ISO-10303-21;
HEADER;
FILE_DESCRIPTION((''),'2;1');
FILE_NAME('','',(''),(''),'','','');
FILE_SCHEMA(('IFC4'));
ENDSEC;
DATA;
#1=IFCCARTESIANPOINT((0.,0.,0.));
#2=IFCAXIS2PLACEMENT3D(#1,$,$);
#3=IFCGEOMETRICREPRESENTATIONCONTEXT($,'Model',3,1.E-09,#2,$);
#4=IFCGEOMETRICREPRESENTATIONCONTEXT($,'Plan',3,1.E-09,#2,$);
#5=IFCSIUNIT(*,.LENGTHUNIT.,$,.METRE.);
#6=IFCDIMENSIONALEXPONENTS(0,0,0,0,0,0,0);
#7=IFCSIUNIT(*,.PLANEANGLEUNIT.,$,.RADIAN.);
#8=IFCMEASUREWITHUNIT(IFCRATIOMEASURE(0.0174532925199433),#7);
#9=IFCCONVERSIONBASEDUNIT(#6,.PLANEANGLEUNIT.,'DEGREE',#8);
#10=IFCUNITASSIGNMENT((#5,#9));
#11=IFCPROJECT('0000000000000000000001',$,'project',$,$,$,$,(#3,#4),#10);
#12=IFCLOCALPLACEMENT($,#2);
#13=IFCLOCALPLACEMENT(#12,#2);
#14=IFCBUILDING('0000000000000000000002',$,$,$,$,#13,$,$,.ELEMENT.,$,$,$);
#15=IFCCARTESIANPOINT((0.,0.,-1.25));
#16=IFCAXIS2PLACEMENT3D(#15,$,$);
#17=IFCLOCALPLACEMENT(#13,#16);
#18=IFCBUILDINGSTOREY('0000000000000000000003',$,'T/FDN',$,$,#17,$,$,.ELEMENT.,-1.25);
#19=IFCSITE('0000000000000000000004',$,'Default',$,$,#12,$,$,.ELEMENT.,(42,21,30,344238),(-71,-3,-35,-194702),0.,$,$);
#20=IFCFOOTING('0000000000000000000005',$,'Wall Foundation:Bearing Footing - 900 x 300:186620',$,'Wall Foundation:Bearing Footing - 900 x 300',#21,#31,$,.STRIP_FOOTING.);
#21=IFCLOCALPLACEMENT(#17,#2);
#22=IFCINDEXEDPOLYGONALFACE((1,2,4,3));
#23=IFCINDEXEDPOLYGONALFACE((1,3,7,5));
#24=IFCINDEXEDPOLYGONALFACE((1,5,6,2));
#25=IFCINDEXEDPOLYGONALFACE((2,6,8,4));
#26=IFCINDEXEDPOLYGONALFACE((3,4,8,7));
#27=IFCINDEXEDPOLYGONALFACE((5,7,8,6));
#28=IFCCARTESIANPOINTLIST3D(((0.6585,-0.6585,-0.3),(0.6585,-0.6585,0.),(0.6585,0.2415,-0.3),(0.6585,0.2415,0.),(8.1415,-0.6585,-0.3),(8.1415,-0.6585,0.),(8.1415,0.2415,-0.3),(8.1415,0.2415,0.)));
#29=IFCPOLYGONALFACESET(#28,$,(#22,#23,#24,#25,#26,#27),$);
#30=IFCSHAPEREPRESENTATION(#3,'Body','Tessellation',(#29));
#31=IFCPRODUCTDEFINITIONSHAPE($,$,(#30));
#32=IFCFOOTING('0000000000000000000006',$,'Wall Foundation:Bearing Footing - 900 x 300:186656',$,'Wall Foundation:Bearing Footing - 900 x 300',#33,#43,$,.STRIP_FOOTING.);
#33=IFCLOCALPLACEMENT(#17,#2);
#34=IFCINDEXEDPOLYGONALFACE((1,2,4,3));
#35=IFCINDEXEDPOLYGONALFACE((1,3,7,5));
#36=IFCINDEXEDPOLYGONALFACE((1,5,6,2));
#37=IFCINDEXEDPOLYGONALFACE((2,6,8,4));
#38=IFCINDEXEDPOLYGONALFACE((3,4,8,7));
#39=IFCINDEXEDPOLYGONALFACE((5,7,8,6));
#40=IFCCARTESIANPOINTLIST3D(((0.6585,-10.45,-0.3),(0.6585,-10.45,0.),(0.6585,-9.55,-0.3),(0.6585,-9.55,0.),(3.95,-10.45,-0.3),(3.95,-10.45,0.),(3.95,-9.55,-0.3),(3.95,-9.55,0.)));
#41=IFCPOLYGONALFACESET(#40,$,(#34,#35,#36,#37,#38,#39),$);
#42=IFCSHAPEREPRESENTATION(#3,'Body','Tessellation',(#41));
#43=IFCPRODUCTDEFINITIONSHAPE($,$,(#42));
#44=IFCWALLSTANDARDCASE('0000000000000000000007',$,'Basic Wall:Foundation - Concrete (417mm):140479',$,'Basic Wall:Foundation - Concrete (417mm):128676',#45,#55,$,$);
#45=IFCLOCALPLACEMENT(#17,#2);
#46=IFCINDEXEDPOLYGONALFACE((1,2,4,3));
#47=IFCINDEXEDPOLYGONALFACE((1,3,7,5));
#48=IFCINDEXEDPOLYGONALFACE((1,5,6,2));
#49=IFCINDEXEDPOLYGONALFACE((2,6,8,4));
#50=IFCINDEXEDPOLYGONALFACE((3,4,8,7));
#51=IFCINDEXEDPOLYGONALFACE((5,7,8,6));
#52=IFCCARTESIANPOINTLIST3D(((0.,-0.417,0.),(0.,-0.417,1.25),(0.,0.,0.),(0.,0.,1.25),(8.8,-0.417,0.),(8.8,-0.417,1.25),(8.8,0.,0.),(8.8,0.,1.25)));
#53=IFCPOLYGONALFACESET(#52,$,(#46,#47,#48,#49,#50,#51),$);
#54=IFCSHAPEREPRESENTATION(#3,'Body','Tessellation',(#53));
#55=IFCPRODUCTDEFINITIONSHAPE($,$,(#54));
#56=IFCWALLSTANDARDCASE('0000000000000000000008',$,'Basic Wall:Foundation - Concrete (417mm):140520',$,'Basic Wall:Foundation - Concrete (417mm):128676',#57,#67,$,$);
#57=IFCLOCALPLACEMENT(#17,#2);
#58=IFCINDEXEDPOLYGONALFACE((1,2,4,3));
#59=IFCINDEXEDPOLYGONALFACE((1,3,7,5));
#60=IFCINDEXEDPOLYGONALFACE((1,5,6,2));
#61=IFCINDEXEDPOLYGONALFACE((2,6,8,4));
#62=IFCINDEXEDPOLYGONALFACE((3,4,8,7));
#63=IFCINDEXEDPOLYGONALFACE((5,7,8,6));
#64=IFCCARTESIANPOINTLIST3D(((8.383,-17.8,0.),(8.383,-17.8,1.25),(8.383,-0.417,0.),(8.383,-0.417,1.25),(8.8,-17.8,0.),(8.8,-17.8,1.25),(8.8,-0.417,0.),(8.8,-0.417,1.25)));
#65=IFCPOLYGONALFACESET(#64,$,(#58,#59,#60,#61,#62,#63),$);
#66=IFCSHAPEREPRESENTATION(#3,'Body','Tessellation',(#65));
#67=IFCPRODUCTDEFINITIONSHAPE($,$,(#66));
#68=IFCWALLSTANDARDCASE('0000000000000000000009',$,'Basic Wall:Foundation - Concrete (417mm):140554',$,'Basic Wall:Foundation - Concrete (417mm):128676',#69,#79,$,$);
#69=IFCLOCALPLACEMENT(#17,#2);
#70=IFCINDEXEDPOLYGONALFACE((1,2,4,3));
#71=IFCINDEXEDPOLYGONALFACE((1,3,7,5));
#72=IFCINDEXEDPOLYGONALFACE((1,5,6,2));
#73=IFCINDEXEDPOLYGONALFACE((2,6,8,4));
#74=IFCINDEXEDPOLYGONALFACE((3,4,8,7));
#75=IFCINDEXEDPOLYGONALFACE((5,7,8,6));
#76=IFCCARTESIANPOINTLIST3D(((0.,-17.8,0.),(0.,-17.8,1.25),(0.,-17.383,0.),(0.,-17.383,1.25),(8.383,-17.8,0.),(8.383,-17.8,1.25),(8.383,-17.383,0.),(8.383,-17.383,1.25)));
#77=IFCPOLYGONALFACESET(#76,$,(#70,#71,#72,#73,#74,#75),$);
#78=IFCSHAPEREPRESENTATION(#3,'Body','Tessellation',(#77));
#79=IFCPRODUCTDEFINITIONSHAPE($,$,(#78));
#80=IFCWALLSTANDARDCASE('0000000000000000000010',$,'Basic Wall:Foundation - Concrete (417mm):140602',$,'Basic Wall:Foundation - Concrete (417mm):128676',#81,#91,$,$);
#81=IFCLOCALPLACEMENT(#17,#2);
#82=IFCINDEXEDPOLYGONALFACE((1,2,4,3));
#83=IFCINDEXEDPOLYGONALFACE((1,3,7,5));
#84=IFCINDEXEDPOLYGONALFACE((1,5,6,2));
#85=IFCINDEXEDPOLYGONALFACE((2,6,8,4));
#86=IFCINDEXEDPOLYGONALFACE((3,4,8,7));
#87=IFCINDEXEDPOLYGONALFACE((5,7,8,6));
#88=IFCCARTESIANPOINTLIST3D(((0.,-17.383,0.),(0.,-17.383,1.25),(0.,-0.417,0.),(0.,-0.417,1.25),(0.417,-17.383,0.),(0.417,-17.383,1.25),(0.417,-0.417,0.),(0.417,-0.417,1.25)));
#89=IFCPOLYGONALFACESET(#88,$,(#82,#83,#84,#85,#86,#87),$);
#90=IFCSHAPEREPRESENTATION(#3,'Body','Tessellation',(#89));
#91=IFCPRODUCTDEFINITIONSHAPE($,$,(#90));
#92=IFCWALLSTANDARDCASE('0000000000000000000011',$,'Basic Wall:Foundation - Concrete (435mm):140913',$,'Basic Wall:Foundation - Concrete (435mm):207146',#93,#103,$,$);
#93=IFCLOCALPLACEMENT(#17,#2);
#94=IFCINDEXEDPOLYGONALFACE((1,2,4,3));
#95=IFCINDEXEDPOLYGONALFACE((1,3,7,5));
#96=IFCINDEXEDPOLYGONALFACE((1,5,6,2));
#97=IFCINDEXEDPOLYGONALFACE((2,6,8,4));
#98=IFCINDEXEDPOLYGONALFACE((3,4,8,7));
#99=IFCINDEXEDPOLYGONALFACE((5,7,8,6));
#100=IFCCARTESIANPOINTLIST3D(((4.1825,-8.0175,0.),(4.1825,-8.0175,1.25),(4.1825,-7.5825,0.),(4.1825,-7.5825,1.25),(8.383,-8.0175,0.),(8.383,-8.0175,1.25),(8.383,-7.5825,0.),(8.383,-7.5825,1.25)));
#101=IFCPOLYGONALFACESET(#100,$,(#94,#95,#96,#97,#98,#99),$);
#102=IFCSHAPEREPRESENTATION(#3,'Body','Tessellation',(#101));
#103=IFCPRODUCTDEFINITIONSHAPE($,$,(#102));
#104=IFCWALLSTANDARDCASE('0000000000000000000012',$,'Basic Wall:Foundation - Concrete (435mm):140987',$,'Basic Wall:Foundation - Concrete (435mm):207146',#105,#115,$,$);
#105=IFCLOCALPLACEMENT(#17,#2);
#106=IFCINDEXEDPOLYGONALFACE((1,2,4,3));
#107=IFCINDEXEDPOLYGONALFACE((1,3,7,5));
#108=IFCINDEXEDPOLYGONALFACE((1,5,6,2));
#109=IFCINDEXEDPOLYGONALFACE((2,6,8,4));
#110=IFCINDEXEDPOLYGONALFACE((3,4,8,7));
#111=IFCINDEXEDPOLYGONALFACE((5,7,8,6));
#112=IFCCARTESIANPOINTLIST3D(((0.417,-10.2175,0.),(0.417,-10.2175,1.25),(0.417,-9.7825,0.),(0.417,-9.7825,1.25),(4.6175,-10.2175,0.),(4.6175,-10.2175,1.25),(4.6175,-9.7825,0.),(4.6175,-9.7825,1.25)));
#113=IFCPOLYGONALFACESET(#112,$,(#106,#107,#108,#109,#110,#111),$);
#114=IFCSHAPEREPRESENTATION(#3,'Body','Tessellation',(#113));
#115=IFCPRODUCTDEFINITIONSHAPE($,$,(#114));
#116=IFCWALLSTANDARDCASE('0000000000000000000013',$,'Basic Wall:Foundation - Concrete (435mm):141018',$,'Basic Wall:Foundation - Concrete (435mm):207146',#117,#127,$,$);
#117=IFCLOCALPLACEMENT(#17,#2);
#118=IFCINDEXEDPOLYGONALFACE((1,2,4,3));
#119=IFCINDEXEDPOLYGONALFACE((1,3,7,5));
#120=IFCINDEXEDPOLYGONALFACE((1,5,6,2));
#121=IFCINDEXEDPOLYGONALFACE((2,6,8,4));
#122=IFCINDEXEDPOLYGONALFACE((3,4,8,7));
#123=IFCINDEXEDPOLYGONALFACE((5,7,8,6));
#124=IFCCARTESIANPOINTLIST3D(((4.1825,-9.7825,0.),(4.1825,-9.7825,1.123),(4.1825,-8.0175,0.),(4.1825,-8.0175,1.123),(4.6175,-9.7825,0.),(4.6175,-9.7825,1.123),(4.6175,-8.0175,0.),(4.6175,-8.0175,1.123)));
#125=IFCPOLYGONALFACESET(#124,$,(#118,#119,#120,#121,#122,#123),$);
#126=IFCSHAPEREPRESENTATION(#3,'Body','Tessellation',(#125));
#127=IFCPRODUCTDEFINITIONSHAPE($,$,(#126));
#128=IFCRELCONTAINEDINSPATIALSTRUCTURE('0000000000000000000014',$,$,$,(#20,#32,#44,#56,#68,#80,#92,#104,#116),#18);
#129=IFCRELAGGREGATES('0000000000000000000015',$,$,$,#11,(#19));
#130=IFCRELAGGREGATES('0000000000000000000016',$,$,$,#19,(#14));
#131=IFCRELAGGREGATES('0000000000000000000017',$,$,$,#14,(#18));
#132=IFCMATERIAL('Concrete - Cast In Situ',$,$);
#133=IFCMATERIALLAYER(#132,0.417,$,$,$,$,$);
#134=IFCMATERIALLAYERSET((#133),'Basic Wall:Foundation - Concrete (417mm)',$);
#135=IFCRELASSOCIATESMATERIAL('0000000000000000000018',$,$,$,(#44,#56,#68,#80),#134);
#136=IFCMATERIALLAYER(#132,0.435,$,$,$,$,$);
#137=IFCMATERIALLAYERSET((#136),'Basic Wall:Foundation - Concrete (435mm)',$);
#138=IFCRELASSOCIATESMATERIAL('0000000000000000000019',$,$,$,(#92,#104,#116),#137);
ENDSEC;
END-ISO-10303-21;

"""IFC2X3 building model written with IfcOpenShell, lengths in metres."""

from ifc_helpers import new_model, entity, si_unit, converted_unit, frame, frame_2d, origin, origin_2d_with_axis, place, context, project, spatial, rectangle, extrude, material, layer, layer_set, layer_usage, element, save


model = new_model("IFC2X3")

# Units and contexts
model_context = context("Model", 3, precision=1e-09, world=origin())
plan_context = context("Plan", 3, precision=1e-09, world=origin())
ifc_project = project(units=[si_unit("LENGTHUNIT", "METRE"), converted_unit("PLANEANGLEUNIT", "DEGREE", entity("IfcRatioMeasure", 0.0174532925199433), si_unit("PLANEANGLEUNIT", "RADIAN"), dimensions=[0, 0, 0, 0, 0, 0, 0])], contexts=[model_context, plan_context])

# Site, building, storey
site_placement = place(None, origin())
site = spatial("IfcSite", under=ifc_project, at=site_placement, Name="Default", CompositionType="ELEMENT", RefLatitude=(42, 21, 30, 344238), RefLongitude=(-71, -3, -35, -194702), RefElevation=0.0)
building_placement = place(site_placement, origin())
building = spatial("IfcBuilding", under=site, at=building_placement, CompositionType="ELEMENT")
storey_placement = place(building_placement, frame((0.0, 0.0, -1.25)))
storey = spatial("IfcBuildingStorey", under=building, at=storey_placement, Name="T/FDN", CompositionType="ELEMENT", Elevation=-1.25)

# Footings
placement = place(storey_placement, origin())
element("IfcFooting", 1, at=placement, inside=storey, Name="Wall Foundation:Bearing Footing - 900 x 300:186620", ObjectType="Wall Foundation:Bearing Footing - 900 x 300", PredefinedType="STRIP_FOOTING", context=model_context, shape_type="SweptSolid", body=[
    extrude(rectangle(XDim=7.483, YDim=0.9, at=origin_2d_with_axis()), frame((4.4, -0.2085, -0.3), z_axis=(0.0, 0.0, 1.0), x_axis=(-1.0, 0.0, 0.0)), (0.0, 0.0, 1.0), 0.3),
])
element("IfcFooting", 2, at=placement, inside=storey, Name="Wall Foundation:Bearing Footing - 900 x 300:186656", ObjectType="Wall Foundation:Bearing Footing - 900 x 300", PredefinedType="STRIP_FOOTING", context=model_context, shape_type="SweptSolid", body=[
    extrude(rectangle(XDim=3.2915, YDim=0.9, at=origin_2d_with_axis()), frame((2.3043, -10.0, -0.3)), (0.0, 0.0, 1.0), 0.3),
])

# Walls
ifc_material = material(Name="Concrete - Cast In Situ")
ifc_layer_1 = layer(ifc_material, 0.417)
ifc_layer_set_1 = layer_set([ifc_layer_1], Name="Basic Wall:Foundation - Concrete (417mm)")
ifc_layer_usage_1 = layer_usage(ifc_layer_set_1, "AXIS2", "NEGATIVE", 0.2085)
wall_1_placement = place(storey_placement, frame((0.0, -0.2085, 0.0)))
element("IfcWallStandardCase", 3, at=wall_1_placement, inside=storey, material=ifc_layer_usage_1, Name="Basic Wall:Foundation - Concrete (417mm):140479", ObjectType="Basic Wall:Foundation - Concrete (417mm):128676", context=model_context, shape_type="SweptSolid", body=[
    extrude(rectangle(XDim=8.8, YDim=0.417, at=frame_2d((4.4, 0.0), x_axis=(-1.0, 0.0))), origin(), (0.0, 0.0, 1.0), 1.25),
])
wall_2_placement = place(storey_placement, frame((8.5915, -0.417, 0.0), z_axis=(0.0, 0.0, 1.0), x_axis=(0.0, -1.0, 0.0)))
element("IfcWallStandardCase", 4, at=wall_2_placement, inside=storey, material=ifc_layer_usage_1, Name="Basic Wall:Foundation - Concrete (417mm):140520", ObjectType="Basic Wall:Foundation - Concrete (417mm):128676", context=model_context, shape_type="SweptSolid", body=[
    extrude(rectangle(XDim=17.383, YDim=0.417, at=frame_2d((8.6915, 0.0), x_axis=(-1.0, 0.0))), origin(), (0.0, 0.0, 1.0), 1.25),
])
wall_3_placement = place(storey_placement, frame((8.383, -17.5915, 0.0), z_axis=(0.0, 0.0, 1.0), x_axis=(-1.0, 0.0, 0.0)))
element("IfcWallStandardCase", 5, at=wall_3_placement, inside=storey, material=ifc_layer_usage_1, Name="Basic Wall:Foundation - Concrete (417mm):140554", ObjectType="Basic Wall:Foundation - Concrete (417mm):128676", context=model_context, shape_type="SweptSolid", body=[
    extrude(rectangle(XDim=8.383, YDim=0.417, at=frame_2d((4.1915, 0.0), x_axis=(-1.0, 0.0))), origin(), (0.0, 0.0, 1.0), 1.25),
])
wall_4_placement = place(storey_placement, frame((0.2085, -17.383, 0.0), z_axis=(0.0, 0.0, 1.0), x_axis=(0.0, 1.0, 0.0)))
element("IfcWallStandardCase", 6, at=wall_4_placement, inside=storey, material=ifc_layer_usage_1, Name="Basic Wall:Foundation - Concrete (417mm):140602", ObjectType="Basic Wall:Foundation - Concrete (417mm):128676", context=model_context, shape_type="SweptSolid", body=[
    extrude(rectangle(XDim=16.966, YDim=0.417, at=frame_2d((8.483, 0.0), x_axis=(-1.0, 0.0))), origin(), (0.0, 0.0, 1.0), 1.25),
])
ifc_layer_2 = layer(ifc_material, 0.435)
ifc_layer_set_2 = layer_set([ifc_layer_2], Name="Basic Wall:Foundation - Concrete (435mm)")
ifc_layer_usage_2 = layer_usage(ifc_layer_set_2, "AXIS2", "NEGATIVE", 0.2175)
wall_5_placement = place(storey_placement, frame((8.383, -7.8, 0.0), z_axis=(0.0, 0.0, 1.0), x_axis=(-1.0, 0.0, 0.0)))
element("IfcWallStandardCase", 7, at=wall_5_placement, inside=storey, material=ifc_layer_usage_2, Name="Basic Wall:Foundation - Concrete (435mm):140913", ObjectType="Basic Wall:Foundation - Concrete (435mm):207146", context=model_context, shape_type="SweptSolid", body=[
    extrude(rectangle(XDim=4.2005, YDim=0.435, at=frame_2d((2.1002, 0.0), x_axis=(-1.0, 0.0))), origin(), (0.0, 0.0, 1.0), 1.25),
])
wall_6_placement = place(storey_placement, frame((0.417, -10.0, 0.0)))
element("IfcWallStandardCase", 8, at=wall_6_placement, inside=storey, material=ifc_layer_usage_2, Name="Basic Wall:Foundation - Concrete (435mm):140987", ObjectType="Basic Wall:Foundation - Concrete (435mm):207146", context=model_context, shape_type="SweptSolid", body=[
    extrude(rectangle(XDim=4.2005, YDim=0.435, at=frame_2d((2.1002, 0.0), x_axis=(-1.0, 0.0))), origin(), (0.0, 0.0, 1.0), 1.25),
])
wall_7_placement = place(storey_placement, frame((4.4, -9.7825, 0.0), z_axis=(0.0, 0.0, 1.0), x_axis=(0.0, 1.0, 0.0)))
element("IfcWallStandardCase", 9, at=wall_7_placement, inside=storey, material=ifc_layer_usage_2, Name="Basic Wall:Foundation - Concrete (435mm):141018", ObjectType="Basic Wall:Foundation - Concrete (435mm):207146", context=model_context, shape_type="SweptSolid", body=[
    extrude(rectangle(XDim=1.765, YDim=0.435, at=frame_2d((0.8825, 0.0), x_axis=(-1.0, 0.0))), origin(), (0.0, 0.0, 1.0), 1.123),
])

save(model, "model.ifc")
